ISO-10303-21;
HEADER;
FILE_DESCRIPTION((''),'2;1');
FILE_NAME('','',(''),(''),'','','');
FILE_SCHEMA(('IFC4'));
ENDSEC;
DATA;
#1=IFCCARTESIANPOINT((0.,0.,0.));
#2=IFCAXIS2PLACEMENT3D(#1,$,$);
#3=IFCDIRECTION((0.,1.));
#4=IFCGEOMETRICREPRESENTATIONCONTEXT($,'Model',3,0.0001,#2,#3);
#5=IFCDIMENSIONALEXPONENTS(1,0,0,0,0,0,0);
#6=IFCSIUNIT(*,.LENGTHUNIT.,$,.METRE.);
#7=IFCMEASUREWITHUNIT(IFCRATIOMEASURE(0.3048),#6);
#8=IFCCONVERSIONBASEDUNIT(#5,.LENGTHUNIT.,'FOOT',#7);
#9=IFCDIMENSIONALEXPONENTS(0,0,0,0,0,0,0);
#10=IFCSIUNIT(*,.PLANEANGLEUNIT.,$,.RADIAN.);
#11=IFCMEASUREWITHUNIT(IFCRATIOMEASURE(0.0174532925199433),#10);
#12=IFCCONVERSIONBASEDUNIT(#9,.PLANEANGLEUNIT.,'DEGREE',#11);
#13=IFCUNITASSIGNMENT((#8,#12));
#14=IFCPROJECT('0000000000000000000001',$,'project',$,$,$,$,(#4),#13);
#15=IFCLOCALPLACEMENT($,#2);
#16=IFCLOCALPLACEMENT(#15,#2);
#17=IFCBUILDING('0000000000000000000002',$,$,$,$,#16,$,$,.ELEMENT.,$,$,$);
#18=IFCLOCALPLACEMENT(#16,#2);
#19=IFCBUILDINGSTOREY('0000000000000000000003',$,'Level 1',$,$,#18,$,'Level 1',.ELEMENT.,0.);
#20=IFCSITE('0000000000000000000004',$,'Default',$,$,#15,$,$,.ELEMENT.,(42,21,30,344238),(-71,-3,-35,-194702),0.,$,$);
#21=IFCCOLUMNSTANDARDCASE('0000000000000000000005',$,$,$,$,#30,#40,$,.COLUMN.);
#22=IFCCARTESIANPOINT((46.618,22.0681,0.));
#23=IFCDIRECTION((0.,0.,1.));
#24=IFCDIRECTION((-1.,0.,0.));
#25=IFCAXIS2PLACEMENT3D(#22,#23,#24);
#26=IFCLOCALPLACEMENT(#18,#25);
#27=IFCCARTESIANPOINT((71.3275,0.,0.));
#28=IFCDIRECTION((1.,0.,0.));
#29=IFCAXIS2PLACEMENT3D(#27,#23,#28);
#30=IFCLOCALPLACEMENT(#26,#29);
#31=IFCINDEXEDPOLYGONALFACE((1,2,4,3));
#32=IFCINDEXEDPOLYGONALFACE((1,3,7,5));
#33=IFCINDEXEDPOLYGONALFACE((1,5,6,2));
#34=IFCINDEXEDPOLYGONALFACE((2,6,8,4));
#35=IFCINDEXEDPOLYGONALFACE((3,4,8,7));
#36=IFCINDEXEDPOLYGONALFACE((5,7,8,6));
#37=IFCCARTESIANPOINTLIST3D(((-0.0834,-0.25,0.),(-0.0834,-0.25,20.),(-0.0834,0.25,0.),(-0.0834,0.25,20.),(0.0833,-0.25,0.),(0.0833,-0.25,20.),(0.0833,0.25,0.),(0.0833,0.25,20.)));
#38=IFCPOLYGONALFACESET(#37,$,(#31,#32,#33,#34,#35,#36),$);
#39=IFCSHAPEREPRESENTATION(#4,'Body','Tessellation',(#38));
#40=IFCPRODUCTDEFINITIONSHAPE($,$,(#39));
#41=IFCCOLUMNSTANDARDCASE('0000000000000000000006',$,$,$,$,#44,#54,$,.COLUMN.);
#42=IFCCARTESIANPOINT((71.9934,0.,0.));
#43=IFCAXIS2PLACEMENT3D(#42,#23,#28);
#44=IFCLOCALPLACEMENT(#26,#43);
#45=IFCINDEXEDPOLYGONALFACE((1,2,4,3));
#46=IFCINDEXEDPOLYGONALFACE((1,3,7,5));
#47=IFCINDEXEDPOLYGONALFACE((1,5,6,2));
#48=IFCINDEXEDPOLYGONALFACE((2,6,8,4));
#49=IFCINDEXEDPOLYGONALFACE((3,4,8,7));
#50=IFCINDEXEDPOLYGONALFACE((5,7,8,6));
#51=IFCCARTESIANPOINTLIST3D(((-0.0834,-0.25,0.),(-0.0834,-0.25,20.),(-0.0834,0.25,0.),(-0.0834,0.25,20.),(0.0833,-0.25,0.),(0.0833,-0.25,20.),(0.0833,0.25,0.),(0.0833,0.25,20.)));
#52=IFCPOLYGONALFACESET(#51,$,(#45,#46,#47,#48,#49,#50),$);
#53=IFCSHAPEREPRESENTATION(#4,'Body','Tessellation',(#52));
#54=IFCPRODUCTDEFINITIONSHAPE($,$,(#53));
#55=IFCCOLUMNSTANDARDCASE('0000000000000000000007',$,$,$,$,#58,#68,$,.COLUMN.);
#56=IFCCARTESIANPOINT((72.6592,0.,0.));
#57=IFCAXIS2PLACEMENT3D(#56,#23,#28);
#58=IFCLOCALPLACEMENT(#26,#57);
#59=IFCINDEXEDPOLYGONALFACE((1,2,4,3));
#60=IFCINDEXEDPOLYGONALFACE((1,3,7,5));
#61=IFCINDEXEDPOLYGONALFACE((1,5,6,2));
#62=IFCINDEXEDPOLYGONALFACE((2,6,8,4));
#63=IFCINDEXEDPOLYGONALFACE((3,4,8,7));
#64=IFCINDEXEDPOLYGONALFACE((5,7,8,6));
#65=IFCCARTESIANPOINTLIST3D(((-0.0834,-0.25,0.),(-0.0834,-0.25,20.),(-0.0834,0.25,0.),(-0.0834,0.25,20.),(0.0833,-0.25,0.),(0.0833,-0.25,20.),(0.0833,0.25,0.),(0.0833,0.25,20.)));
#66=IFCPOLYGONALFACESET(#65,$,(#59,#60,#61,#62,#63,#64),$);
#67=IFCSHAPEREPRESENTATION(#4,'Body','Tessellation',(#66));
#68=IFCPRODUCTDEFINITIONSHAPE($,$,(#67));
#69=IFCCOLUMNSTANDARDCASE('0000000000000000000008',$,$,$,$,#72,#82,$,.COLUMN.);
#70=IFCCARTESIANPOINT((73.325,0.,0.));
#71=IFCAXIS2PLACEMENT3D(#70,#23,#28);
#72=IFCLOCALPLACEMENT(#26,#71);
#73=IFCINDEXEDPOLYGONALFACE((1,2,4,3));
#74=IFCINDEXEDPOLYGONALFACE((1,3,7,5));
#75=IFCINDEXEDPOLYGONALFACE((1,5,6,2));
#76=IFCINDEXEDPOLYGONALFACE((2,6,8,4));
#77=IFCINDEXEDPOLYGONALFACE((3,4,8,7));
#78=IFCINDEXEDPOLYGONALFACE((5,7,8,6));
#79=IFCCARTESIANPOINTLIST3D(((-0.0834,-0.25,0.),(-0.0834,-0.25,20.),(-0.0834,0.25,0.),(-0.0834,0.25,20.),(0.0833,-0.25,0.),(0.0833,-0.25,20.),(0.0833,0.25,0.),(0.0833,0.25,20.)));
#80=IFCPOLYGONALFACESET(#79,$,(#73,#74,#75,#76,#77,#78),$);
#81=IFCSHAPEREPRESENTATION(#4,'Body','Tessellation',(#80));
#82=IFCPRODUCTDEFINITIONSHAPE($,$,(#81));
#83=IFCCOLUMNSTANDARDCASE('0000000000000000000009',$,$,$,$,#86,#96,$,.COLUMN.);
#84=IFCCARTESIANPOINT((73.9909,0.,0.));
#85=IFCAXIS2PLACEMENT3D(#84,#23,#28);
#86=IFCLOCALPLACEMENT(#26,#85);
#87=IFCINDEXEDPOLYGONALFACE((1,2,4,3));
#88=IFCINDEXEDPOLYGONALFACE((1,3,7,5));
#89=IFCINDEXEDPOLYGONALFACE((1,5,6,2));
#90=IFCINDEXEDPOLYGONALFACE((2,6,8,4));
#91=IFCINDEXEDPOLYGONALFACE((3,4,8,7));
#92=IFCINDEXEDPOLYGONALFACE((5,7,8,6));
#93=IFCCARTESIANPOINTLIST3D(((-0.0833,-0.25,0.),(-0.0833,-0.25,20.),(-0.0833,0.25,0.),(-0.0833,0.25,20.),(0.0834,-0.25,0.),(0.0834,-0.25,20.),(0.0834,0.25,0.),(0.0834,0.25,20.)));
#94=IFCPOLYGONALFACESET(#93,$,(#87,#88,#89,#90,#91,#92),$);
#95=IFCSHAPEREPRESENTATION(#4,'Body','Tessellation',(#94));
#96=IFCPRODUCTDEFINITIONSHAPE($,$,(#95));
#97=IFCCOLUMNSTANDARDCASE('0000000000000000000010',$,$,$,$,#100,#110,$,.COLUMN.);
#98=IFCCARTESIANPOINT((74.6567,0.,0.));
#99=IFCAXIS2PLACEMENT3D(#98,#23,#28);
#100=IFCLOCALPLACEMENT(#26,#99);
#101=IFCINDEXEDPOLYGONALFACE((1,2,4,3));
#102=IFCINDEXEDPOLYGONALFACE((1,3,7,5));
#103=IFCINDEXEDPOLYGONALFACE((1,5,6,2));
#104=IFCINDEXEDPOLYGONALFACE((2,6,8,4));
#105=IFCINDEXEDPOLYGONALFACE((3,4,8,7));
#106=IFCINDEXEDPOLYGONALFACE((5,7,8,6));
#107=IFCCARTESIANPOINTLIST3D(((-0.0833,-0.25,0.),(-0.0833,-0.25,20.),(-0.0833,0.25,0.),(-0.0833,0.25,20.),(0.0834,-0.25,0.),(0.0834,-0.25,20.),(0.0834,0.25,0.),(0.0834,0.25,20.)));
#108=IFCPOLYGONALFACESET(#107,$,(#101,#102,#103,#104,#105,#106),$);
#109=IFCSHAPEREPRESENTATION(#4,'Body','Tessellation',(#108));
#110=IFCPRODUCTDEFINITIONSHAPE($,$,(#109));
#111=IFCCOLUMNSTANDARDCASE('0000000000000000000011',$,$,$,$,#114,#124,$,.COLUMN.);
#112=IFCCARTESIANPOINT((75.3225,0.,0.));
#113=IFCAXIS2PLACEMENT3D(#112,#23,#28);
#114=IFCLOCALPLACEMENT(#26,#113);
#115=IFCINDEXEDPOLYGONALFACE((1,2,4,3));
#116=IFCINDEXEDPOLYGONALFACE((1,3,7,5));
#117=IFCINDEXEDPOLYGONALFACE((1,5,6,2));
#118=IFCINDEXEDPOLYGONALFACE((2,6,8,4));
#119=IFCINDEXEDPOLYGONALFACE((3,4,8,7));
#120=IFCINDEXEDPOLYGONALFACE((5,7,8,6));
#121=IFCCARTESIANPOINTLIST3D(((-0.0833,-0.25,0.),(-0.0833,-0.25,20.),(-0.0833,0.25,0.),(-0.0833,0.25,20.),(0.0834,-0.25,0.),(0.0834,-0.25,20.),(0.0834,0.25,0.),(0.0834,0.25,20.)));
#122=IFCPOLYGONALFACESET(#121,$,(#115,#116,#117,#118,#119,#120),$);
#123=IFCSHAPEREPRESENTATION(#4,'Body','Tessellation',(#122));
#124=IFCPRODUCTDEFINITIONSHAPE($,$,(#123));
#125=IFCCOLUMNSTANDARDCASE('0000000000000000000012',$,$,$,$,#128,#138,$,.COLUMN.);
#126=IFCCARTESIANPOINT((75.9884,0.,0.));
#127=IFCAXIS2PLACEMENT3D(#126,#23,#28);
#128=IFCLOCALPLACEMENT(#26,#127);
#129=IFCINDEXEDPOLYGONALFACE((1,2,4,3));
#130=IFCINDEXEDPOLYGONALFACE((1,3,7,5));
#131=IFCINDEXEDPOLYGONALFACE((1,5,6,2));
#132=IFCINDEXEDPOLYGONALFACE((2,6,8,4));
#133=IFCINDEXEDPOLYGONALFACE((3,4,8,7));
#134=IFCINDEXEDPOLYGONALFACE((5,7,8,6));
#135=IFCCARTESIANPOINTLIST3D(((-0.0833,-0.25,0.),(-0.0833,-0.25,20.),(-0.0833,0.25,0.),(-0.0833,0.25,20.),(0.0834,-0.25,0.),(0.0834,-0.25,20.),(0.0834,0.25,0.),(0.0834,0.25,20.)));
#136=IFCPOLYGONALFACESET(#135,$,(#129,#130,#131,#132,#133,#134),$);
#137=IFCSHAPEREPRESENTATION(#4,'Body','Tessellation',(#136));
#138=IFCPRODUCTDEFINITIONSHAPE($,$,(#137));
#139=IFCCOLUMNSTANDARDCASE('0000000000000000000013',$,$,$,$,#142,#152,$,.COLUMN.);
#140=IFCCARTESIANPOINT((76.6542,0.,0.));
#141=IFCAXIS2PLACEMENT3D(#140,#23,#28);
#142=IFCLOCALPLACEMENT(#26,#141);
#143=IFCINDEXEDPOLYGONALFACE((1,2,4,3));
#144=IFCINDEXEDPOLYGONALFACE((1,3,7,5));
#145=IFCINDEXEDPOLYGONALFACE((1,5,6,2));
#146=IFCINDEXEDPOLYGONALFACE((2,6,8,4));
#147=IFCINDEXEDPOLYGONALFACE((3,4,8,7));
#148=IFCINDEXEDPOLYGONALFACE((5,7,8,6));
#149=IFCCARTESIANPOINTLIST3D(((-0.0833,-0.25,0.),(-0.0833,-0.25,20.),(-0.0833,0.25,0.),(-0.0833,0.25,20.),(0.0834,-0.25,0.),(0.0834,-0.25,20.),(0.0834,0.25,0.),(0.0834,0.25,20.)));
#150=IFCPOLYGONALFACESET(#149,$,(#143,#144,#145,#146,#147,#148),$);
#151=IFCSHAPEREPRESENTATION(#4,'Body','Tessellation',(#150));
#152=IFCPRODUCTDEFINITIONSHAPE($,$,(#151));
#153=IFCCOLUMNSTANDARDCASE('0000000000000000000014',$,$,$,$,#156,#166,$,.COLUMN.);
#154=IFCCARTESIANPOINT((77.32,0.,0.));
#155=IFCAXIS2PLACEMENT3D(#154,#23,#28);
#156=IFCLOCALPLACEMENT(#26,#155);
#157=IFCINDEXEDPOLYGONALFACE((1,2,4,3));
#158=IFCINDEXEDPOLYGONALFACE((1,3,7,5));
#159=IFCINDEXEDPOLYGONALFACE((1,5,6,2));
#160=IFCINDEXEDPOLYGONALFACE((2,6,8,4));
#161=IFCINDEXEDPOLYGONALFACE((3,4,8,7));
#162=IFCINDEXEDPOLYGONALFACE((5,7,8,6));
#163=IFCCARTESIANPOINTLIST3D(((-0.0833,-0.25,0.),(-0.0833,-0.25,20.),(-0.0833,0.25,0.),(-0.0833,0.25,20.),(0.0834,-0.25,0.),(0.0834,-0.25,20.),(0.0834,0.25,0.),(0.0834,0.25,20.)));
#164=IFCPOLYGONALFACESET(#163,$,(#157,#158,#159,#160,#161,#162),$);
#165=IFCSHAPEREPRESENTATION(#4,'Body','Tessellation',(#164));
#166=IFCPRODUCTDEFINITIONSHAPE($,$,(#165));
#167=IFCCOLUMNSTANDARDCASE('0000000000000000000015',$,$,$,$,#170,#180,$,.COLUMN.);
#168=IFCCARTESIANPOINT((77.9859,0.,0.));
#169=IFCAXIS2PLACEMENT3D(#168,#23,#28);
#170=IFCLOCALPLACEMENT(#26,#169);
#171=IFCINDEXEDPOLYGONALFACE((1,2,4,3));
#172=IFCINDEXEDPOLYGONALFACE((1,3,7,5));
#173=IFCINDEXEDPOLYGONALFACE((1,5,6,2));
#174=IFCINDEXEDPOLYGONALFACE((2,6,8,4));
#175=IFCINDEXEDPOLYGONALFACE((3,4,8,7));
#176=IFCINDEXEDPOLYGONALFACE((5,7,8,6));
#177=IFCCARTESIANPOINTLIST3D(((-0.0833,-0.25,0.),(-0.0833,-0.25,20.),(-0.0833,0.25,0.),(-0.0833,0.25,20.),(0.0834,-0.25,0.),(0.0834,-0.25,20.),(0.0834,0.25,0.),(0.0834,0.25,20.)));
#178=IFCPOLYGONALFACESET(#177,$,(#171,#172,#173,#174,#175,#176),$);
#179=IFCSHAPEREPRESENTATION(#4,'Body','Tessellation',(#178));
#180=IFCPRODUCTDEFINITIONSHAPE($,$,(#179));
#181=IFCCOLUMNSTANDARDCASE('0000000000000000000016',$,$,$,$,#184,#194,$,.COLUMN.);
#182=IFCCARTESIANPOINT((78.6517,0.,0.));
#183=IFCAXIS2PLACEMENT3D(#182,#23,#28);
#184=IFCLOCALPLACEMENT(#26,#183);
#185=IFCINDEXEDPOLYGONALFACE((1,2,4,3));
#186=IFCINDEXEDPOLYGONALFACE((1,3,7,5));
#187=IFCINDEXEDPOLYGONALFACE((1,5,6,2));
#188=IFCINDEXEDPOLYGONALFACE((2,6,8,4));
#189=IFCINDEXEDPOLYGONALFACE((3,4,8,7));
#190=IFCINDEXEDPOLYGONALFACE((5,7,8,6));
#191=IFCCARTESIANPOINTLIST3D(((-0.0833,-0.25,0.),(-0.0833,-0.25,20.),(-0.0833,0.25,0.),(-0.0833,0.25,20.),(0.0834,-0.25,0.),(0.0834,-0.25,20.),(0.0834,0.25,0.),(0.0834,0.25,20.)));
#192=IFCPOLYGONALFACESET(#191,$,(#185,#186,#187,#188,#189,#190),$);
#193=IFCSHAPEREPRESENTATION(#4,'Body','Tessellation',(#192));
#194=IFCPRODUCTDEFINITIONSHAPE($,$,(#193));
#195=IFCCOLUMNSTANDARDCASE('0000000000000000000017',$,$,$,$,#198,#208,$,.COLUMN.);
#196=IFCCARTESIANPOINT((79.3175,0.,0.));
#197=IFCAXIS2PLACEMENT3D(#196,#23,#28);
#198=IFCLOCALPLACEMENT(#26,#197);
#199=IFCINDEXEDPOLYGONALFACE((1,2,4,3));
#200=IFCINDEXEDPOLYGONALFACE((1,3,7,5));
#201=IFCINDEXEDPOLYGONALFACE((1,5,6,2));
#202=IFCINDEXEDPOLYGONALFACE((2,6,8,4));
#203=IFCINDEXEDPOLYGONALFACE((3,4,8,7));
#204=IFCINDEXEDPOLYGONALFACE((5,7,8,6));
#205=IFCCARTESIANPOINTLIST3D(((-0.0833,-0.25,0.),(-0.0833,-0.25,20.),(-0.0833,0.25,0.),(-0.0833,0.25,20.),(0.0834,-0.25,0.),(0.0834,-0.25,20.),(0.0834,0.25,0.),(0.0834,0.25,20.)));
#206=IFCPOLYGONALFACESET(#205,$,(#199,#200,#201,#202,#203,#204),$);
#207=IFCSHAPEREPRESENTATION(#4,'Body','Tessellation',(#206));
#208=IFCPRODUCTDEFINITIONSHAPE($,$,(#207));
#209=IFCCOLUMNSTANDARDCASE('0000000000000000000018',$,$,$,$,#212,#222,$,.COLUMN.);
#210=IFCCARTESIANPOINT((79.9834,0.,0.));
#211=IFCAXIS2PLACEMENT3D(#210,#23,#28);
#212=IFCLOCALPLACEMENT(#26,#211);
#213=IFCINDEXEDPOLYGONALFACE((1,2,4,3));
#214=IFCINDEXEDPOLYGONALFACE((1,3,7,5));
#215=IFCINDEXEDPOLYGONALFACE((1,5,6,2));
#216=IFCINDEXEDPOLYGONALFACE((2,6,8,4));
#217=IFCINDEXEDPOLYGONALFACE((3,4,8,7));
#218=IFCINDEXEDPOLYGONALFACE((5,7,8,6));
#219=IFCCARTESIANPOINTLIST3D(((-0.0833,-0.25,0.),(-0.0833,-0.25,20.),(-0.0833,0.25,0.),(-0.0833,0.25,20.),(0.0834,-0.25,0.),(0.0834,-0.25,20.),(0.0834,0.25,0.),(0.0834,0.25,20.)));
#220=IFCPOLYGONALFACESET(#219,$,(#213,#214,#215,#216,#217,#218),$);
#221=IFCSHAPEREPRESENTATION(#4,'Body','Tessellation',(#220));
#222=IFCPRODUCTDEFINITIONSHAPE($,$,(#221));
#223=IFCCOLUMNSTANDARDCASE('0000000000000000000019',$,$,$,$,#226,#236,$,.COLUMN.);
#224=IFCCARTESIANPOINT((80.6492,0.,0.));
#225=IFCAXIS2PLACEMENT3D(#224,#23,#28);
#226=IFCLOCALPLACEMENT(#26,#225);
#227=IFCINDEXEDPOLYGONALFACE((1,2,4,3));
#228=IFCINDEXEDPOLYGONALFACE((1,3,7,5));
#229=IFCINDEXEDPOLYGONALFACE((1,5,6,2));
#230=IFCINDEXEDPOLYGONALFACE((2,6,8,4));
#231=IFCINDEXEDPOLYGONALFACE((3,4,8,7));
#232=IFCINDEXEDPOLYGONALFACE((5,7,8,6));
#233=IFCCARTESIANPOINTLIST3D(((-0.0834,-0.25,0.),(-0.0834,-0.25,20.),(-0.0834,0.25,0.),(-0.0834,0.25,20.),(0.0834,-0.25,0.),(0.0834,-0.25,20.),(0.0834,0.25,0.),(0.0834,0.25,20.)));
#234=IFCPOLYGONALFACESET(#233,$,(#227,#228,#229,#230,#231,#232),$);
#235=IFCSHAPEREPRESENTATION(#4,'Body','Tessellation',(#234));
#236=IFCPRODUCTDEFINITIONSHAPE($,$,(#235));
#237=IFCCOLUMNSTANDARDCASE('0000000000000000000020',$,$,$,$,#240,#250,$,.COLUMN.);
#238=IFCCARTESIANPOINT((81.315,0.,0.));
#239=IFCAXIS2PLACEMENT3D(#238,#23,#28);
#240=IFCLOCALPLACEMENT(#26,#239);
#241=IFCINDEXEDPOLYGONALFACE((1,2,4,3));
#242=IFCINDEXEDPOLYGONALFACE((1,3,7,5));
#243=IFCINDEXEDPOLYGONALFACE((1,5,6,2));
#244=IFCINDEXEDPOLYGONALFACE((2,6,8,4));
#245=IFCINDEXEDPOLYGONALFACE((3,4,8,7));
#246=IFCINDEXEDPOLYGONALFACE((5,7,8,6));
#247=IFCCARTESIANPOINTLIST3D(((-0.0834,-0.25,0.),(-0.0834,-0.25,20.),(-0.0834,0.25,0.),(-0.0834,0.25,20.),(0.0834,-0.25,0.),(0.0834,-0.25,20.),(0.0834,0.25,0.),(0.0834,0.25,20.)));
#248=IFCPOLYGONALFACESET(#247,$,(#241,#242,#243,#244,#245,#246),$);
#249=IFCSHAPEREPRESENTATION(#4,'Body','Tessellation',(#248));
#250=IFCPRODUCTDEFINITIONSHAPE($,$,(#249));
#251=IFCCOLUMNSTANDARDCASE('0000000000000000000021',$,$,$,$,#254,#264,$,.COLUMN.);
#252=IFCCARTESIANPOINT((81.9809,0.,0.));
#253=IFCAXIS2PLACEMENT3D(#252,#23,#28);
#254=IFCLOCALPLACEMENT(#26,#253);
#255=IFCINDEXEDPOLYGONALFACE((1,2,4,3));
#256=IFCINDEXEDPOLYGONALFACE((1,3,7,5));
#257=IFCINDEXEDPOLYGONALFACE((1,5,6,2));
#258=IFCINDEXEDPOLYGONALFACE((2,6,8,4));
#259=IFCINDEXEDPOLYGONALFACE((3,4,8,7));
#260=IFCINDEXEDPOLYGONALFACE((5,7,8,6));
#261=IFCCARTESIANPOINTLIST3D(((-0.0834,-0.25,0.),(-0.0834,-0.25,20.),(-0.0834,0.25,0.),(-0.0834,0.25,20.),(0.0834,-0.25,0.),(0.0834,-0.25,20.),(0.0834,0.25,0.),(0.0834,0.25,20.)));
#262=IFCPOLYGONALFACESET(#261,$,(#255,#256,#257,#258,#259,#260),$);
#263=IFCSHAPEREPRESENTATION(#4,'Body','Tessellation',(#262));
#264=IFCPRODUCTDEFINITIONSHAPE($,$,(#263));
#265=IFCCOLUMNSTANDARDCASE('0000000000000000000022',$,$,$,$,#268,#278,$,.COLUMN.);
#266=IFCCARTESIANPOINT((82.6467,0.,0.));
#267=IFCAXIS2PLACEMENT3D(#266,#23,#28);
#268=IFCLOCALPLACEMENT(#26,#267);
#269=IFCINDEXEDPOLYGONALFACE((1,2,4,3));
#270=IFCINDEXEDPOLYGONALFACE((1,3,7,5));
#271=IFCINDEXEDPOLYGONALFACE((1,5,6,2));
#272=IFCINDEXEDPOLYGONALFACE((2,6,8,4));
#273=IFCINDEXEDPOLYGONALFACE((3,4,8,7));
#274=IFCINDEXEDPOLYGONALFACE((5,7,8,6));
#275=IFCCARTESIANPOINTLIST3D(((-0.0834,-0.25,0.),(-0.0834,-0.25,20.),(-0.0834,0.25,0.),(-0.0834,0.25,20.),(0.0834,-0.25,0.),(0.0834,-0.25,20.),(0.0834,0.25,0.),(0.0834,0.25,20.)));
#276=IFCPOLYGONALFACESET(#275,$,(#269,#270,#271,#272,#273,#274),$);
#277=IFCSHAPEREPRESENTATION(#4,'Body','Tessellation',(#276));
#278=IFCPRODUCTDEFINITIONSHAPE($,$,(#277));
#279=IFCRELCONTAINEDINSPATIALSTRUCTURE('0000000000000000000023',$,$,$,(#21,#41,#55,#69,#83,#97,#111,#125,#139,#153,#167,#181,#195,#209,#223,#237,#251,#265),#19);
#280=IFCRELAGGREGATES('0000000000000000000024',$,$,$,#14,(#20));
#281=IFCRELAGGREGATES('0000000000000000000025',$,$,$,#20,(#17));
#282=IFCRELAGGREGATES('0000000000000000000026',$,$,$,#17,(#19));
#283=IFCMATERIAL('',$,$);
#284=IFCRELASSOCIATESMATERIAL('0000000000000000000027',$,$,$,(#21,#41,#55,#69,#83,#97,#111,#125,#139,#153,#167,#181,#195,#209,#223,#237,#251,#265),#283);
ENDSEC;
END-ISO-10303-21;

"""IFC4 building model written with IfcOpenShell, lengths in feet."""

from ifc_helpers import new_model, entity, si_unit, converted_unit, direction, frame, origin, place, context, project, spatial, rectangle, extrude, material, element, save


model = new_model("IFC4")

# Units and contexts
model_context = context("Model", 3, precision=0.0001, world=origin(), true_north=direction((0.0, 1.0)))
ifc_project = project(units=[converted_unit("LENGTHUNIT", "FOOT", entity("IfcRatioMeasure", 0.3048), si_unit("LENGTHUNIT", "METRE"), dimensions=[1, 0, 0, 0, 0, 0, 0]), converted_unit("PLANEANGLEUNIT", "DEGREE", entity("IfcRatioMeasure", 0.0174532925199433), si_unit("PLANEANGLEUNIT", "RADIAN"), dimensions=[0, 0, 0, 0, 0, 0, 0])], contexts=[model_context])

# Site, building, storey
site_placement = place(None, origin())
site = spatial("IfcSite", under=ifc_project, at=site_placement, Name="Default", CompositionType="ELEMENT", RefLatitude=(42, 21, 30, 344238), RefLongitude=(-71, -3, -35, -194702), RefElevation=0.0)
building_placement = place(site_placement, origin())
building = spatial("IfcBuilding", under=site, at=building_placement, CompositionType="ELEMENT")
storey_placement = place(building_placement, origin())
storey = spatial("IfcBuildingStorey", under=building, at=storey_placement, Name="Level 1", LongName="Level 1", CompositionType="ELEMENT", Elevation=0.0)

# Columns
ifc_material = material(Name="")
placement = place(storey_placement, frame((46.618, 22.0681, 0.0), z_axis=(0.0, 0.0, 1.0), x_axis=(-1.0, 0.0, 0.0)))
for number, where, z_axis, x_axis in (
    (1, (71.3275, 0.0, 0.0), (0.0, 0.0, 1.0), (1.0, 0.0, 0.0)),
    (2, (71.9934, 0.0, 0.0), (0.0, 0.0, 1.0), (1.0, 0.0, 0.0)),
    (3, (72.6592, 0.0, 0.0), (0.0, 0.0, 1.0), (1.0, 0.0, 0.0)),
    (4, (73.325, 0.0, 0.0), (0.0, 0.0, 1.0), (1.0, 0.0, 0.0)),
    (5, (73.9909, 0.0, 0.0), (0.0, 0.0, 1.0), (1.0, 0.0, 0.0)),
    (6, (74.6567, 0.0, 0.0), (0.0, 0.0, 1.0), (1.0, 0.0, 0.0)),
    (7, (75.3225, 0.0, 0.0), (0.0, 0.0, 1.0), (1.0, 0.0, 0.0)),
    (8, (75.9884, 0.0, 0.0), (0.0, 0.0, 1.0), (1.0, 0.0, 0.0)),
    (9, (76.6542, 0.0, 0.0), (0.0, 0.0, 1.0), (1.0, 0.0, 0.0)),
    (10, (77.32, 0.0, 0.0), (0.0, 0.0, 1.0), (1.0, 0.0, 0.0)),
    (11, (77.9859, 0.0, 0.0), (0.0, 0.0, 1.0), (1.0, 0.0, 0.0)),
    (12, (78.6517, 0.0, 0.0), (0.0, 0.0, 1.0), (1.0, 0.0, 0.0)),
    (13, (79.3175, 0.0, 0.0), (0.0, 0.0, 1.0), (1.0, 0.0, 0.0)),
    (14, (79.9834, 0.0, 0.0), (0.0, 0.0, 1.0), (1.0, 0.0, 0.0)),
    (15, (80.6492, 0.0, 0.0), (0.0, 0.0, 1.0), (1.0, 0.0, 0.0)),
    (16, (81.315, 0.0, 0.0), (0.0, 0.0, 1.0), (1.0, 0.0, 0.0)),
    (17, (81.9809, 0.0, 0.0), (0.0, 0.0, 1.0), (1.0, 0.0, 0.0)),
    (18, (82.6467, 0.0, 0.0), (0.0, 0.0, 1.0), (1.0, 0.0, 0.0)),
):
    element("IfcColumnStandardCase", number, at=place(placement, frame(where, z_axis=z_axis, x_axis=x_axis)), inside=storey, material=ifc_material, PredefinedType="COLUMN", context=model_context, shape_type="SweptSolid", body=[
        extrude(rectangle(XDim=0.1667, YDim=0.5), origin(), (0.0, 0.0, 1.0), 20.0),
    ])

save(model, "model.ifc")
